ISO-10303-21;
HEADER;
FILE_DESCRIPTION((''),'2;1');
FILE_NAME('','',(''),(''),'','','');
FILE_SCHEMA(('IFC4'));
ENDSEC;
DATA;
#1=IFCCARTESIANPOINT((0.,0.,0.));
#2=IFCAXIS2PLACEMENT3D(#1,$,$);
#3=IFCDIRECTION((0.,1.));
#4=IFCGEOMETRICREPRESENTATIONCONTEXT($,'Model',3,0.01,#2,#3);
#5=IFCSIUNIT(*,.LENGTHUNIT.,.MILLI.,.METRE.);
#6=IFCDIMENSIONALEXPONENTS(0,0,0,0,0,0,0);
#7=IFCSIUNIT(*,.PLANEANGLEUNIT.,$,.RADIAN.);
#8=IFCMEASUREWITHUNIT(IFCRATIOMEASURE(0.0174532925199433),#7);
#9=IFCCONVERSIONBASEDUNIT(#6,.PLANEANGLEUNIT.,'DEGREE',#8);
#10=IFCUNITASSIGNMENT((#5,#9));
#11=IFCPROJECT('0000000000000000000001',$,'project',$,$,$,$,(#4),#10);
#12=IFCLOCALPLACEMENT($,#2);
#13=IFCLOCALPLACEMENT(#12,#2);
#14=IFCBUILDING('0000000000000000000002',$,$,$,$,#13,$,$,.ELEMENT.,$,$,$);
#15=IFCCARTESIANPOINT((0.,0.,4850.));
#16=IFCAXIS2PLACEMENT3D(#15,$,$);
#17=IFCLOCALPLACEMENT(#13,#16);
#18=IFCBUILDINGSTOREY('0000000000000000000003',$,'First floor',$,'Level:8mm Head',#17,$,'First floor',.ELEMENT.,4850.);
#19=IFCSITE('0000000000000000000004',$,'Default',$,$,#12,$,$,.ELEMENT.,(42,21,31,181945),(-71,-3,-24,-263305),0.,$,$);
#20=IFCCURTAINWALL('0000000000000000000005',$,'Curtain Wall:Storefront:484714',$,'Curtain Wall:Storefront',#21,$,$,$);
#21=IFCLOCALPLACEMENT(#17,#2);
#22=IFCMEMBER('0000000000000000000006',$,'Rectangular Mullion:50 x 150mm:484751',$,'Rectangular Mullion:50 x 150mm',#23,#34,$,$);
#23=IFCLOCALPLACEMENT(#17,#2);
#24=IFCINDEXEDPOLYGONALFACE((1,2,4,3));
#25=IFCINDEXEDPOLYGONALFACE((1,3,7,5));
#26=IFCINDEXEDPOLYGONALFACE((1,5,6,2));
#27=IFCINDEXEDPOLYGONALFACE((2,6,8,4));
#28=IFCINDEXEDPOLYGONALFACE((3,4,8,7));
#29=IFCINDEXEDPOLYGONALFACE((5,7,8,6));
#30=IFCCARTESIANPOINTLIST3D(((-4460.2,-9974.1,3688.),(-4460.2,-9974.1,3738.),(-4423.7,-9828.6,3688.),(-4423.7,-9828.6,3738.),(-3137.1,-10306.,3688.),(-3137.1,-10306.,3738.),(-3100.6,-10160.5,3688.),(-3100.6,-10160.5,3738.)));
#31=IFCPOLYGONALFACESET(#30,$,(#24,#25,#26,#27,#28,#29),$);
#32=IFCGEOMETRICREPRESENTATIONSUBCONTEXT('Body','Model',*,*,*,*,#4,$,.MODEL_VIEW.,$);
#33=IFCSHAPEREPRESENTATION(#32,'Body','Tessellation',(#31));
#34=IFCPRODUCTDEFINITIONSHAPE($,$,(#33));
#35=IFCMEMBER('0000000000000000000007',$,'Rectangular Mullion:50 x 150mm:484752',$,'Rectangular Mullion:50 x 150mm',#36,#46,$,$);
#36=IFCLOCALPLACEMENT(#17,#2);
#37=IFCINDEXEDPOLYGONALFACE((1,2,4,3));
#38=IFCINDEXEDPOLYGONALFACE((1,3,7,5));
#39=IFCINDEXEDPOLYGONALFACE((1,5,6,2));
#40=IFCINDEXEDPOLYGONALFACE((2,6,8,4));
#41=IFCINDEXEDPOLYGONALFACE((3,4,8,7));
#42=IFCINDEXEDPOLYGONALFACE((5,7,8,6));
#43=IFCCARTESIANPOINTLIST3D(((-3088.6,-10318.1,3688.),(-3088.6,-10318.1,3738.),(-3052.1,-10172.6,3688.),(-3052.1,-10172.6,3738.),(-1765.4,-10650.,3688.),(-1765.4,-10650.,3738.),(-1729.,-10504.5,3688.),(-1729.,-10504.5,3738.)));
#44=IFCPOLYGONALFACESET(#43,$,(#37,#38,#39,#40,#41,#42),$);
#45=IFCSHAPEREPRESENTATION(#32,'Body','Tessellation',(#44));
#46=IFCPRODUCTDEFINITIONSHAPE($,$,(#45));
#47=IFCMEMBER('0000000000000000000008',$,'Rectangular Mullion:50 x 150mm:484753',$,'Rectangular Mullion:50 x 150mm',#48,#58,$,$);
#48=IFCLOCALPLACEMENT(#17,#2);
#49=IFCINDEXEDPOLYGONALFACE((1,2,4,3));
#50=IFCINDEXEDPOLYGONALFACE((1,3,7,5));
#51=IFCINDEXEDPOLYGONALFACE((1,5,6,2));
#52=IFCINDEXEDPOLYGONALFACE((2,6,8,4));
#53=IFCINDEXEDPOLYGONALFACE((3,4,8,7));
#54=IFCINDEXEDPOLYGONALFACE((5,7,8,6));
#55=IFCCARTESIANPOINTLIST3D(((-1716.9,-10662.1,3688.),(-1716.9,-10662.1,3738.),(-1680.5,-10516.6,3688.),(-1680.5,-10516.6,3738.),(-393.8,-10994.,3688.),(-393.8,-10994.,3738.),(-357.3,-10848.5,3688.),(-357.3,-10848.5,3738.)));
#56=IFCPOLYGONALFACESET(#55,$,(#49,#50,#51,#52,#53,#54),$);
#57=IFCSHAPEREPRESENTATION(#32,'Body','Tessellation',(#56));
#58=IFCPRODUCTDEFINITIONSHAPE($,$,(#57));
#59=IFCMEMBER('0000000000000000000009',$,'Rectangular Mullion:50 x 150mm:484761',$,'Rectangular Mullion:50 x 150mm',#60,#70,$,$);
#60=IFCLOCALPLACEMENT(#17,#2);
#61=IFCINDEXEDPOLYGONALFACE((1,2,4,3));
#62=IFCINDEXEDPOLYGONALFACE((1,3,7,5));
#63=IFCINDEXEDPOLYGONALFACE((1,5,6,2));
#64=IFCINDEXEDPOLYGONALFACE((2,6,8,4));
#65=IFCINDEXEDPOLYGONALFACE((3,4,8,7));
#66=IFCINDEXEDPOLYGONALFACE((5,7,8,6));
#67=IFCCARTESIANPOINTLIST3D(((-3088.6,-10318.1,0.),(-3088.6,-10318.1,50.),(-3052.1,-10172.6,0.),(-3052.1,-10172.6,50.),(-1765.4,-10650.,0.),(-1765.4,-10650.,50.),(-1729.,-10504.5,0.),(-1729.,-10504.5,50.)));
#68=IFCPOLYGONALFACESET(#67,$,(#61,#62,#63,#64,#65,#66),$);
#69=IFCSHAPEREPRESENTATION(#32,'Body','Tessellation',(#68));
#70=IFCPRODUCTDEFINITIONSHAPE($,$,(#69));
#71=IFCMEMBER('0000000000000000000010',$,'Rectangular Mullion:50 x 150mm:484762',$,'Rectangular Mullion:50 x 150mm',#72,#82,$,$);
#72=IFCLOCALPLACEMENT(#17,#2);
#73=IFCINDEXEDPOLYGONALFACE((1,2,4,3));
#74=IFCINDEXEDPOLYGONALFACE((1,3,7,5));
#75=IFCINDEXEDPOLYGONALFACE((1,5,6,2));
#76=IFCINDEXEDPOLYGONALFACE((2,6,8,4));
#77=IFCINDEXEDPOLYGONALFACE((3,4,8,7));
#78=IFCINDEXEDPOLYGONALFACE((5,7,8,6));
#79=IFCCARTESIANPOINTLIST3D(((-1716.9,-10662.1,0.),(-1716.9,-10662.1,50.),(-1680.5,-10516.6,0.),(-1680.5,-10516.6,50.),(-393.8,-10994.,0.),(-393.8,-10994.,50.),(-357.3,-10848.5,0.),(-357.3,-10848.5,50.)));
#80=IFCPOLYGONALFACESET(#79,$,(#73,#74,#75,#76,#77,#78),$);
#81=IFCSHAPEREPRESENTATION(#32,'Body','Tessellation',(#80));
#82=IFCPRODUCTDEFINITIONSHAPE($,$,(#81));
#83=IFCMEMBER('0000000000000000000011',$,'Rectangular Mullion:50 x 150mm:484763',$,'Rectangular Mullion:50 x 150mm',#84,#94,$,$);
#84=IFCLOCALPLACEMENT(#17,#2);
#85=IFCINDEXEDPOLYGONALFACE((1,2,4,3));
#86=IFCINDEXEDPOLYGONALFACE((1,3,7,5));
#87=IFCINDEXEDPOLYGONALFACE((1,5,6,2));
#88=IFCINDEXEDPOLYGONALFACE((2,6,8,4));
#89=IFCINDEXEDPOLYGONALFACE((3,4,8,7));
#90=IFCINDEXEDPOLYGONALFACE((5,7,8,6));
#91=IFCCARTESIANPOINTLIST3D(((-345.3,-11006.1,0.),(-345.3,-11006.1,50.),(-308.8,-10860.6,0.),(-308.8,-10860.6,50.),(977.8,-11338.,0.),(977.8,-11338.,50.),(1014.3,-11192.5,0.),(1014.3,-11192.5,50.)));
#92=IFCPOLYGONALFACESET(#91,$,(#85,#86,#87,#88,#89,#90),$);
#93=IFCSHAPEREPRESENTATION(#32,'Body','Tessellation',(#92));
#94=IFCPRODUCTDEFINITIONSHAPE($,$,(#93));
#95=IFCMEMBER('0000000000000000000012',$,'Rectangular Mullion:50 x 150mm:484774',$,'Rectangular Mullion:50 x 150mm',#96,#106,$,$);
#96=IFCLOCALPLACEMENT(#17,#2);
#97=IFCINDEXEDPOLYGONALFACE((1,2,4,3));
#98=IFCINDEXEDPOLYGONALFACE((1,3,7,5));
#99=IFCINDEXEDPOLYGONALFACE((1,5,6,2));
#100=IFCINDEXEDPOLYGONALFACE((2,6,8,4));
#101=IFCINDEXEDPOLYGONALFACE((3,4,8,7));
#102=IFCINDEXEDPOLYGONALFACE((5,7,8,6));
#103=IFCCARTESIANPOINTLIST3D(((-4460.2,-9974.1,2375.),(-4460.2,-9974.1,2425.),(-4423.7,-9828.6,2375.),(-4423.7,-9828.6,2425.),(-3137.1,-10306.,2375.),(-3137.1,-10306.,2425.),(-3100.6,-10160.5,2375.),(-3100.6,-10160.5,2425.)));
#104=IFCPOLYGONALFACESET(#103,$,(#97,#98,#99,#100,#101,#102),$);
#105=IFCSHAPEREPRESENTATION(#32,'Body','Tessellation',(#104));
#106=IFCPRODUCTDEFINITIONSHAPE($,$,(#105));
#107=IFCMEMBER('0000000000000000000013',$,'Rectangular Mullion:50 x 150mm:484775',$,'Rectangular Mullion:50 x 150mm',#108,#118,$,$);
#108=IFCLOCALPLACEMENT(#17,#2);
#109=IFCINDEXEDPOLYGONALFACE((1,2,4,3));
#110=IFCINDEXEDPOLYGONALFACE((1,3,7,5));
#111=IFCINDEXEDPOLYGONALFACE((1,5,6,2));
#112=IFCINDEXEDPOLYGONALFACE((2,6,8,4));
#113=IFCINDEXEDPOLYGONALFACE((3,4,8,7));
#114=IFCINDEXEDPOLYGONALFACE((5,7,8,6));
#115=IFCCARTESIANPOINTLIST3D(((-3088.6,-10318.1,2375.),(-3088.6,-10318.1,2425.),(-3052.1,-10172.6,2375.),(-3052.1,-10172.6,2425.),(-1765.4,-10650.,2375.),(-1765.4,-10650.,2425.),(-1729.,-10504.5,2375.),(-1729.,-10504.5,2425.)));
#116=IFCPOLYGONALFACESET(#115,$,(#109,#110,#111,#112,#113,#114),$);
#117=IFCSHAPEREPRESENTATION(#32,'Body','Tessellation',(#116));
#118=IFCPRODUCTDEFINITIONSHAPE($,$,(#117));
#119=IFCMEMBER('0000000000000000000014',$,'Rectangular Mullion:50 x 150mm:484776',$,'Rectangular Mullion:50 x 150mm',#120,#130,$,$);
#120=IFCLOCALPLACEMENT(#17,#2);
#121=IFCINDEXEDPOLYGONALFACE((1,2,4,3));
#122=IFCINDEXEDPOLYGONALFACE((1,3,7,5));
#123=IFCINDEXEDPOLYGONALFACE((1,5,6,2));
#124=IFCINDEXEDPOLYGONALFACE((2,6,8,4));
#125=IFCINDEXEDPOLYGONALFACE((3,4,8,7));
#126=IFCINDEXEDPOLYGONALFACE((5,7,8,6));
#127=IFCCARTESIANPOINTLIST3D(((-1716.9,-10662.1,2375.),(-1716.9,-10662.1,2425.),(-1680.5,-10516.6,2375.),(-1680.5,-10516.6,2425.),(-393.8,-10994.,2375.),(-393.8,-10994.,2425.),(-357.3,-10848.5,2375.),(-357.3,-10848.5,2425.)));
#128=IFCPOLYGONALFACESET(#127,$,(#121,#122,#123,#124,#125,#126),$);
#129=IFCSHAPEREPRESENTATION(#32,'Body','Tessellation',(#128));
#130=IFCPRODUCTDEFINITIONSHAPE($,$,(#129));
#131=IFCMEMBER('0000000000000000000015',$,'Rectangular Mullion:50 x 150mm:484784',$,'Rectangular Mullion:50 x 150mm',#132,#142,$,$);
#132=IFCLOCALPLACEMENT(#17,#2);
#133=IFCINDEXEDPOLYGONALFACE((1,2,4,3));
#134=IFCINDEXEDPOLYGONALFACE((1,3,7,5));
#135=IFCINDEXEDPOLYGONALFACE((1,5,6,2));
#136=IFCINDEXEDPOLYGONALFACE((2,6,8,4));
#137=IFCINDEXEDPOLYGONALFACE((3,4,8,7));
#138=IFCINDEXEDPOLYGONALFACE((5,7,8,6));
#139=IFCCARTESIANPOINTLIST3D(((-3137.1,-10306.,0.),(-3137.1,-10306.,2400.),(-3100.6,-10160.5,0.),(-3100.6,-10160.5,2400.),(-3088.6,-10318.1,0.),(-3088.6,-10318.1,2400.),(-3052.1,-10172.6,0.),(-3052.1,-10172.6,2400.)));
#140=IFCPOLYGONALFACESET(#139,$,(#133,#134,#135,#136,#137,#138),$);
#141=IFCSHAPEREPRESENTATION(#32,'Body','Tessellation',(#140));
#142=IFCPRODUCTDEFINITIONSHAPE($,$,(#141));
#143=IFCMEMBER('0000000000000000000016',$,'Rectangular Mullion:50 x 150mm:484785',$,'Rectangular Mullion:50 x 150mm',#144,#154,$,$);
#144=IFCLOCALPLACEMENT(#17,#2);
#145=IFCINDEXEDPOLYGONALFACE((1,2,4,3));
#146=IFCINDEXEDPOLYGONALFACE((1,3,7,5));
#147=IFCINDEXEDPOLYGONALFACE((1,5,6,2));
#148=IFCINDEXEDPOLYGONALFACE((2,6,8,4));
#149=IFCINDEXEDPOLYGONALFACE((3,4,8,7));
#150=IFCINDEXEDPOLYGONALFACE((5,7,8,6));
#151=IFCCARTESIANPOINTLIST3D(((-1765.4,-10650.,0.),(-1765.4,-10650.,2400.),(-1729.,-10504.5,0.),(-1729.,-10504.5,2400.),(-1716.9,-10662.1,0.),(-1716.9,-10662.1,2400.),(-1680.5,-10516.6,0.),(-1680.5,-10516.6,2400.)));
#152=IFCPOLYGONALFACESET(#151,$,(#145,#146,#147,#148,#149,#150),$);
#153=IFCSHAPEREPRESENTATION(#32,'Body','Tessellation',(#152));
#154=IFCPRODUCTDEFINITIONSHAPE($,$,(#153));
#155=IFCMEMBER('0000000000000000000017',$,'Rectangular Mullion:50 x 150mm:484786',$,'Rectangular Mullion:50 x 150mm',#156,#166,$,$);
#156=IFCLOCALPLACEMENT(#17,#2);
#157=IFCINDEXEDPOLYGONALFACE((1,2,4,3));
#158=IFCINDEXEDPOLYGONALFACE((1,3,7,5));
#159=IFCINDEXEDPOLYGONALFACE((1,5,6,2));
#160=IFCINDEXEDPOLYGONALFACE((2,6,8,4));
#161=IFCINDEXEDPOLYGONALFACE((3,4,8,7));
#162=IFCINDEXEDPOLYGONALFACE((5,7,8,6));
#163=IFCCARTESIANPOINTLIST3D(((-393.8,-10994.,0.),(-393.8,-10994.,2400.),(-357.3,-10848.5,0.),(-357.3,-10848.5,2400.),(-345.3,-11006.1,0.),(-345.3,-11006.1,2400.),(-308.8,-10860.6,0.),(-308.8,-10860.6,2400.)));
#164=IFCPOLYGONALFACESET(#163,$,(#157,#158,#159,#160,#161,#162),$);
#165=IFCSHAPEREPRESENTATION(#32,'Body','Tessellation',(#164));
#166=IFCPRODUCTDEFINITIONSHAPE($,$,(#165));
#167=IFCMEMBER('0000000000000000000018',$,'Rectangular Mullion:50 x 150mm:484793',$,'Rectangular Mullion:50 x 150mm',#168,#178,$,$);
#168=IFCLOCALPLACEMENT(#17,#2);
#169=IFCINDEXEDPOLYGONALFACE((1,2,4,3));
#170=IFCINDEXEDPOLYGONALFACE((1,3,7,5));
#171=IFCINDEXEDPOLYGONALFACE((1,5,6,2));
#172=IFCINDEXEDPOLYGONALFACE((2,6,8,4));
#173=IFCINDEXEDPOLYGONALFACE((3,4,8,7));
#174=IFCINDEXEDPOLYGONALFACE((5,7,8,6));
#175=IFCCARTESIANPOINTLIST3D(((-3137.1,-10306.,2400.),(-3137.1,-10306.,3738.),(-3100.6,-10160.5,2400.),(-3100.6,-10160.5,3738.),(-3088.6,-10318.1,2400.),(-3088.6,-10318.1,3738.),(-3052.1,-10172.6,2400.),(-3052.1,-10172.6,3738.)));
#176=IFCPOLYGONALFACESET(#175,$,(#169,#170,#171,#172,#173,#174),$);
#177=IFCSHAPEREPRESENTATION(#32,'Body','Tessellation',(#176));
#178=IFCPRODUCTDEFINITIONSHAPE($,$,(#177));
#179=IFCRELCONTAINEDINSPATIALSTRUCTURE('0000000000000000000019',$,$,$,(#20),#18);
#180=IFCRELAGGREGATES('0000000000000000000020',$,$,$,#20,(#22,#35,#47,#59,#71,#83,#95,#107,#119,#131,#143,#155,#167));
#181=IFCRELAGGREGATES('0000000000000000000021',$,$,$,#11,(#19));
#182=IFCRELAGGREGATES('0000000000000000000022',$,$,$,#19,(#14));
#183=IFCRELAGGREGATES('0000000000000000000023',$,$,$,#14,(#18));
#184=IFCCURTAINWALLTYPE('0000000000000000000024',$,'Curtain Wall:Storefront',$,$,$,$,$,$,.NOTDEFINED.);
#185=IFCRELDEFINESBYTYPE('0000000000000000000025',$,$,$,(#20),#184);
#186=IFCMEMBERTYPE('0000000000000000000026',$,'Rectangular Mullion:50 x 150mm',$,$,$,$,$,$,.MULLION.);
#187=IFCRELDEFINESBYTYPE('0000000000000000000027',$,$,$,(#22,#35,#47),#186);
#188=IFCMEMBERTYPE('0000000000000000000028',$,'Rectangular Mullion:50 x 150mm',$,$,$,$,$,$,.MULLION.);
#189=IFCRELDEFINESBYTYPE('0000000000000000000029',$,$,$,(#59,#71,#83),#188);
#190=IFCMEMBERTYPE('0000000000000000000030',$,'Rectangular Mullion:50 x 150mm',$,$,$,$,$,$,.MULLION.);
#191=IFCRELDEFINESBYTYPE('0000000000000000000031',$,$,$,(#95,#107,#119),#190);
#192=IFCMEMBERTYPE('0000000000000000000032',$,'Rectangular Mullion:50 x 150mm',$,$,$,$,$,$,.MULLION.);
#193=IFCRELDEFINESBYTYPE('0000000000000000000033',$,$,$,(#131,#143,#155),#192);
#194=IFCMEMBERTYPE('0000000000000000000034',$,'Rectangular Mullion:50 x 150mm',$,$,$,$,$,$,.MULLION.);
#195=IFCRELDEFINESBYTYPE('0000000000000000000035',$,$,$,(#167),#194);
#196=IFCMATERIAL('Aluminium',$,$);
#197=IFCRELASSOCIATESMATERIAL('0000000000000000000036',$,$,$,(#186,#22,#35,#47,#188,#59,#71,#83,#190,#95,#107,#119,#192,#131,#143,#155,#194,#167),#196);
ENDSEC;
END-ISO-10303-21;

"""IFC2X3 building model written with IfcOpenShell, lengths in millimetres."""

from ifc_helpers import new_model, entity, si_unit, converted_unit, direction, frame, origin, origin_2d_with_axis, place, context, subcontext, project, spatial, rectangle, extrude, source, transform, mapped, material, type_object, type_shapes, element, aggregate, save


model = new_model("IFC2X3")

# Units and contexts
model_context = context("Model", 3, precision=0.01, world=origin(), true_north=direction((0.0, 1.0)))
body_context = subcontext(model_context, "Body", "Model", "MODEL_VIEW")
ifc_project = project(units=[si_unit("LENGTHUNIT", "METRE", prefix="MILLI"), converted_unit("PLANEANGLEUNIT", "DEGREE", entity("IfcRatioMeasure", 0.0174532925199433), si_unit("PLANEANGLEUNIT", "RADIAN"), dimensions=[0, 0, 0, 0, 0, 0, 0])], contexts=[model_context])

# Site, building, storey
site_placement = place(None, origin())
site = spatial("IfcSite", under=ifc_project, at=site_placement, Name="Default", CompositionType="ELEMENT", RefLatitude=(42, 21, 31, 181945), RefLongitude=(-71, -3, -24, -263305), RefElevation=0.0)
building_placement = place(site_placement, origin())
building = spatial("IfcBuilding", under=site, at=building_placement, CompositionType="ELEMENT")
storey_placement = place(building_placement, frame((0.0, 0.0, 4850.0)))
storey = spatial("IfcBuildingStorey", under=building, at=storey_placement, Name="First floor", ObjectType="Level:8mm Head", LongName="First floor", CompositionType="ELEMENT", Elevation=4850.0)

# Curtain wall, members
curtain_wall_type = type_object("IfcCurtainWallType", Name="Curtain Wall:Storefront", PredefinedType="NOTDEFINED")
curtain_wall_placement = place(storey_placement, frame((0.0, 0.0, -4850.0)))
curtain_wall = element("IfcCurtainWall", 1, at=curtain_wall_placement, inside=storey, type_object=curtain_wall_type, Name="Curtain Wall:Storefront:484714", ObjectType="Curtain Wall:Storefront")
ifc_material_1 = material(Name="Aluminium")
member_type_1 = type_object("IfcMemberType", Name="Rectangular Mullion:50 x 150mm", PredefinedType="MULLION", material=ifc_material_1)
shared_shape_1 = source(origin(), body_context, "Body", "SweptSolid", [
    extrude(rectangle(XDim=150.0, YDim=50.0, at=origin_2d_with_axis()), frame((-25.0, 0.0, -1364.1), z_axis=(0.0, 0.0, 1.0), x_axis=(0.0, -1.0, 0.0)), (0.0, 0.0, 1.0), 1364.1),
])
type_shapes(member_type_1, [shared_shape_1])
member_1_placement = place(storey_placement, frame((-3118.8, -10233.2, 3738.0), z_axis=(0.96996, -0.243265, 0.0), x_axis=(0.0, 0.0, 1.0)))
member_1 = element("IfcMember", 2, at=member_1_placement, type_object=member_type_1, material=ifc_material_1, Name="Rectangular Mullion:50 x 150mm:484751", ObjectType="Rectangular Mullion:50 x 150mm", context=body_context, shape_type="MappedRepresentation", body=[
    mapped(shared_shape_1, transform((0.0, 0.0, 0.0), scale=1.0)),
])
member_2_placement = place(storey_placement, frame((-1747.2, -10577.2, 3738.0), z_axis=(0.96996, -0.243265, 0.0), x_axis=(0.0, 0.0, 1.0)))
member_2 = element("IfcMember", 3, at=member_2_placement, type_object=member_type_1, material=ifc_material_1, Name="Rectangular Mullion:50 x 150mm:484752", ObjectType="Rectangular Mullion:50 x 150mm", context=body_context, shape_type="MappedRepresentation", body=[
    mapped(shared_shape_1, transform((0.0, 0.0, 0.0), scale=1.0)),
])
member_3_placement = place(storey_placement, frame((-375.6, -10921.2, 3738.0), z_axis=(0.96996, -0.243265, 0.0), x_axis=(0.0, 0.0, 1.0)))
member_3 = element("IfcMember", 4, at=member_3_placement, type_object=member_type_1, material=ifc_material_1, Name="Rectangular Mullion:50 x 150mm:484753", ObjectType="Rectangular Mullion:50 x 150mm", context=body_context, shape_type="MappedRepresentation", body=[
    mapped(shared_shape_1, transform((0.0, 0.0, 0.0), scale=1.0)),
])
member_type_2 = type_object("IfcMemberType", Name="Rectangular Mullion:50 x 150mm", PredefinedType="MULLION", material=ifc_material_1)
shared_shape_2 = source(origin(), body_context, "Body", "SweptSolid", [
    extrude(rectangle(XDim=150.0, YDim=50.0, at=origin_2d_with_axis()), frame((-25.0, 0.0, -1364.1), z_axis=(0.0, 0.0, 1.0), x_axis=(0.0, -1.0, 0.0)), (0.0, 0.0, 1.0), 1364.1),
])
type_shapes(member_type_2, [shared_shape_2])
member_4_placement = place(storey_placement, frame((-3070.3, -10245.4, 0.0), z_axis=(-0.96996, 0.243265, 0.0), x_axis=(0.0, 0.0, -1.0)))
member_4 = element("IfcMember", 5, at=member_4_placement, type_object=member_type_2, material=ifc_material_1, Name="Rectangular Mullion:50 x 150mm:484761", ObjectType="Rectangular Mullion:50 x 150mm", context=body_context, shape_type="MappedRepresentation", body=[
    mapped(shared_shape_2, transform((0.0, 0.0, 0.0), scale=1.0)),
])
member_5_placement = place(storey_placement, frame((-1698.7, -10589.4, 0.0), z_axis=(-0.96996, 0.243265, 0.0), x_axis=(0.0, 0.0, -1.0)))
member_5 = element("IfcMember", 6, at=member_5_placement, type_object=member_type_2, material=ifc_material_1, Name="Rectangular Mullion:50 x 150mm:484762", ObjectType="Rectangular Mullion:50 x 150mm", context=body_context, shape_type="MappedRepresentation", body=[
    mapped(shared_shape_2, transform((0.0, 0.0, 0.0), scale=1.0)),
])
member_6_placement = place(storey_placement, frame((-327.1, -10933.4, 0.0), z_axis=(-0.96996, 0.243265, 0.0), x_axis=(0.0, 0.0, -1.0)))
member_6 = element("IfcMember", 7, at=member_6_placement, type_object=member_type_2, material=ifc_material_1, Name="Rectangular Mullion:50 x 150mm:484763", ObjectType="Rectangular Mullion:50 x 150mm", context=body_context, shape_type="MappedRepresentation", body=[
    mapped(shared_shape_2, transform((0.0, 0.0, 0.0), scale=1.0)),
])
member_type_3 = type_object("IfcMemberType", Name="Rectangular Mullion:50 x 150mm", PredefinedType="MULLION", material=ifc_material_1)
shared_shape_3 = source(origin(), body_context, "Body", "SweptSolid", [
    extrude(rectangle(XDim=150.0, YDim=50.0, at=origin_2d_with_axis()), frame((0.0, 0.0, -1364.1), z_axis=(0.0, 0.0, 1.0), x_axis=(0.0, -1.0, 0.0)), (0.0, 0.0, 1.0), 1364.1),
])
type_shapes(member_type_3, [shared_shape_3])
member_7_placement = place(storey_placement, frame((-3118.8, -10233.2, 2400.0), z_axis=(0.96996, -0.243265, 0.0), x_axis=(0.0, 0.0, 1.0)))
member_7 = element("IfcMember", 8, at=member_7_placement, type_object=member_type_3, material=ifc_material_1, Name="Rectangular Mullion:50 x 150mm:484774", ObjectType="Rectangular Mullion:50 x 150mm", context=body_context, shape_type="MappedRepresentation", body=[
    mapped(shared_shape_3, transform((0.0, 0.0, 0.0), scale=1.0)),
])
member_8_placement = place(storey_placement, frame((-1747.2, -10577.2, 2400.0), z_axis=(0.96996, -0.243265, 0.0), x_axis=(0.0, 0.0, 1.0)))
member_8 = element("IfcMember", 9, at=member_8_placement, type_object=member_type_3, material=ifc_material_1, Name="Rectangular Mullion:50 x 150mm:484775", ObjectType="Rectangular Mullion:50 x 150mm", context=body_context, shape_type="MappedRepresentation", body=[
    mapped(shared_shape_3, transform((0.0, 0.0, 0.0), scale=1.0)),
])
member_9_placement = place(storey_placement, frame((-375.6, -10921.2, 2400.0), z_axis=(0.96996, -0.243265, 0.0), x_axis=(0.0, 0.0, 1.0)))
member_9 = element("IfcMember", 10, at=member_9_placement, type_object=member_type_3, material=ifc_material_1, Name="Rectangular Mullion:50 x 150mm:484776", ObjectType="Rectangular Mullion:50 x 150mm", context=body_context, shape_type="MappedRepresentation", body=[
    mapped(shared_shape_3, transform((0.0, 0.0, 0.0), scale=1.0)),
])
member_type_4 = type_object("IfcMemberType", Name="Rectangular Mullion:50 x 150mm", PredefinedType="MULLION", material=ifc_material_1)
shared_shape_4 = source(origin(), body_context, "Body", "SweptSolid", [
    extrude(rectangle(XDim=150.0, YDim=50.0, at=origin_2d_with_axis()), frame((0.0, 0.0, -2400.0), z_axis=(0.0, 0.0, 1.0), x_axis=(0.0, -1.0, 0.0)), (0.0, 0.0, 1.0), 2400.0),
])
type_shapes(member_type_4, [shared_shape_4])
member_10_placement = place(storey_placement, frame((-3094.6, -10239.3, 0.0), z_axis=(0.0, 0.0, -1.0), x_axis=(0.96996, -0.243265, 0.0)))
member_10 = element("IfcMember", 11, at=member_10_placement, type_object=member_type_4, material=ifc_material_1, Name="Rectangular Mullion:50 x 150mm:484784", ObjectType="Rectangular Mullion:50 x 150mm", context=body_context, shape_type="MappedRepresentation", body=[
    mapped(shared_shape_4, transform((0.0, 0.0, 0.0), scale=1.0)),
])
member_11_placement = place(storey_placement, frame((-1722.9, -10583.3, 0.0), z_axis=(0.0, 0.0, -1.0), x_axis=(0.96996, -0.243265, 0.0)))
member_11 = element("IfcMember", 12, at=member_11_placement, type_object=member_type_4, material=ifc_material_1, Name="Rectangular Mullion:50 x 150mm:484785", ObjectType="Rectangular Mullion:50 x 150mm", context=body_context, shape_type="MappedRepresentation", body=[
    mapped(shared_shape_4, transform((0.0, 0.0, 0.0), scale=1.0)),
])
member_12_placement = place(storey_placement, frame((-351.3, -10927.3, 0.0), z_axis=(0.0, 0.0, -1.0), x_axis=(0.96996, -0.243265, 0.0)))
member_12 = element("IfcMember", 13, at=member_12_placement, type_object=member_type_4, material=ifc_material_1, Name="Rectangular Mullion:50 x 150mm:484786", ObjectType="Rectangular Mullion:50 x 150mm", context=body_context, shape_type="MappedRepresentation", body=[
    mapped(shared_shape_4, transform((0.0, 0.0, 0.0), scale=1.0)),
])
member_type_5 = type_object("IfcMemberType", Name="Rectangular Mullion:50 x 150mm", PredefinedType="MULLION", material=ifc_material_1)
shared_shape_5 = source(origin(), body_context, "Body", "SweptSolid", [
    extrude(rectangle(XDim=150.0, YDim=50.0, at=origin_2d_with_axis()), frame((0.0, 0.0, -1338.0), z_axis=(0.0, 0.0, 1.0), x_axis=(0.0, -1.0, 0.0)), (0.0, 0.0, 1.0), 1338.0),
])
type_shapes(member_type_5, [shared_shape_5])
member_13_placement = place(storey_placement, frame((-3094.6, -10239.3, 2400.0), z_axis=(0.0, 0.0, -1.0), x_axis=(0.96996, -0.243265, 0.0)))
member_13 = element("IfcMember", 14, at=member_13_placement, type_object=member_type_5, material=ifc_material_1, Name="Rectangular Mullion:50 x 150mm:484793", ObjectType="Rectangular Mullion:50 x 150mm", context=body_context, shape_type="MappedRepresentation", body=[
    mapped(shared_shape_5, transform((0.0, 0.0, 0.0), scale=1.0)),
])
aggregate(curtain_wall, [member_1, member_2, member_3, member_4, member_5, member_6, member_7, member_8, member_9, member_10, member_11, member_12, member_13])

save(model, "model.ifc")
